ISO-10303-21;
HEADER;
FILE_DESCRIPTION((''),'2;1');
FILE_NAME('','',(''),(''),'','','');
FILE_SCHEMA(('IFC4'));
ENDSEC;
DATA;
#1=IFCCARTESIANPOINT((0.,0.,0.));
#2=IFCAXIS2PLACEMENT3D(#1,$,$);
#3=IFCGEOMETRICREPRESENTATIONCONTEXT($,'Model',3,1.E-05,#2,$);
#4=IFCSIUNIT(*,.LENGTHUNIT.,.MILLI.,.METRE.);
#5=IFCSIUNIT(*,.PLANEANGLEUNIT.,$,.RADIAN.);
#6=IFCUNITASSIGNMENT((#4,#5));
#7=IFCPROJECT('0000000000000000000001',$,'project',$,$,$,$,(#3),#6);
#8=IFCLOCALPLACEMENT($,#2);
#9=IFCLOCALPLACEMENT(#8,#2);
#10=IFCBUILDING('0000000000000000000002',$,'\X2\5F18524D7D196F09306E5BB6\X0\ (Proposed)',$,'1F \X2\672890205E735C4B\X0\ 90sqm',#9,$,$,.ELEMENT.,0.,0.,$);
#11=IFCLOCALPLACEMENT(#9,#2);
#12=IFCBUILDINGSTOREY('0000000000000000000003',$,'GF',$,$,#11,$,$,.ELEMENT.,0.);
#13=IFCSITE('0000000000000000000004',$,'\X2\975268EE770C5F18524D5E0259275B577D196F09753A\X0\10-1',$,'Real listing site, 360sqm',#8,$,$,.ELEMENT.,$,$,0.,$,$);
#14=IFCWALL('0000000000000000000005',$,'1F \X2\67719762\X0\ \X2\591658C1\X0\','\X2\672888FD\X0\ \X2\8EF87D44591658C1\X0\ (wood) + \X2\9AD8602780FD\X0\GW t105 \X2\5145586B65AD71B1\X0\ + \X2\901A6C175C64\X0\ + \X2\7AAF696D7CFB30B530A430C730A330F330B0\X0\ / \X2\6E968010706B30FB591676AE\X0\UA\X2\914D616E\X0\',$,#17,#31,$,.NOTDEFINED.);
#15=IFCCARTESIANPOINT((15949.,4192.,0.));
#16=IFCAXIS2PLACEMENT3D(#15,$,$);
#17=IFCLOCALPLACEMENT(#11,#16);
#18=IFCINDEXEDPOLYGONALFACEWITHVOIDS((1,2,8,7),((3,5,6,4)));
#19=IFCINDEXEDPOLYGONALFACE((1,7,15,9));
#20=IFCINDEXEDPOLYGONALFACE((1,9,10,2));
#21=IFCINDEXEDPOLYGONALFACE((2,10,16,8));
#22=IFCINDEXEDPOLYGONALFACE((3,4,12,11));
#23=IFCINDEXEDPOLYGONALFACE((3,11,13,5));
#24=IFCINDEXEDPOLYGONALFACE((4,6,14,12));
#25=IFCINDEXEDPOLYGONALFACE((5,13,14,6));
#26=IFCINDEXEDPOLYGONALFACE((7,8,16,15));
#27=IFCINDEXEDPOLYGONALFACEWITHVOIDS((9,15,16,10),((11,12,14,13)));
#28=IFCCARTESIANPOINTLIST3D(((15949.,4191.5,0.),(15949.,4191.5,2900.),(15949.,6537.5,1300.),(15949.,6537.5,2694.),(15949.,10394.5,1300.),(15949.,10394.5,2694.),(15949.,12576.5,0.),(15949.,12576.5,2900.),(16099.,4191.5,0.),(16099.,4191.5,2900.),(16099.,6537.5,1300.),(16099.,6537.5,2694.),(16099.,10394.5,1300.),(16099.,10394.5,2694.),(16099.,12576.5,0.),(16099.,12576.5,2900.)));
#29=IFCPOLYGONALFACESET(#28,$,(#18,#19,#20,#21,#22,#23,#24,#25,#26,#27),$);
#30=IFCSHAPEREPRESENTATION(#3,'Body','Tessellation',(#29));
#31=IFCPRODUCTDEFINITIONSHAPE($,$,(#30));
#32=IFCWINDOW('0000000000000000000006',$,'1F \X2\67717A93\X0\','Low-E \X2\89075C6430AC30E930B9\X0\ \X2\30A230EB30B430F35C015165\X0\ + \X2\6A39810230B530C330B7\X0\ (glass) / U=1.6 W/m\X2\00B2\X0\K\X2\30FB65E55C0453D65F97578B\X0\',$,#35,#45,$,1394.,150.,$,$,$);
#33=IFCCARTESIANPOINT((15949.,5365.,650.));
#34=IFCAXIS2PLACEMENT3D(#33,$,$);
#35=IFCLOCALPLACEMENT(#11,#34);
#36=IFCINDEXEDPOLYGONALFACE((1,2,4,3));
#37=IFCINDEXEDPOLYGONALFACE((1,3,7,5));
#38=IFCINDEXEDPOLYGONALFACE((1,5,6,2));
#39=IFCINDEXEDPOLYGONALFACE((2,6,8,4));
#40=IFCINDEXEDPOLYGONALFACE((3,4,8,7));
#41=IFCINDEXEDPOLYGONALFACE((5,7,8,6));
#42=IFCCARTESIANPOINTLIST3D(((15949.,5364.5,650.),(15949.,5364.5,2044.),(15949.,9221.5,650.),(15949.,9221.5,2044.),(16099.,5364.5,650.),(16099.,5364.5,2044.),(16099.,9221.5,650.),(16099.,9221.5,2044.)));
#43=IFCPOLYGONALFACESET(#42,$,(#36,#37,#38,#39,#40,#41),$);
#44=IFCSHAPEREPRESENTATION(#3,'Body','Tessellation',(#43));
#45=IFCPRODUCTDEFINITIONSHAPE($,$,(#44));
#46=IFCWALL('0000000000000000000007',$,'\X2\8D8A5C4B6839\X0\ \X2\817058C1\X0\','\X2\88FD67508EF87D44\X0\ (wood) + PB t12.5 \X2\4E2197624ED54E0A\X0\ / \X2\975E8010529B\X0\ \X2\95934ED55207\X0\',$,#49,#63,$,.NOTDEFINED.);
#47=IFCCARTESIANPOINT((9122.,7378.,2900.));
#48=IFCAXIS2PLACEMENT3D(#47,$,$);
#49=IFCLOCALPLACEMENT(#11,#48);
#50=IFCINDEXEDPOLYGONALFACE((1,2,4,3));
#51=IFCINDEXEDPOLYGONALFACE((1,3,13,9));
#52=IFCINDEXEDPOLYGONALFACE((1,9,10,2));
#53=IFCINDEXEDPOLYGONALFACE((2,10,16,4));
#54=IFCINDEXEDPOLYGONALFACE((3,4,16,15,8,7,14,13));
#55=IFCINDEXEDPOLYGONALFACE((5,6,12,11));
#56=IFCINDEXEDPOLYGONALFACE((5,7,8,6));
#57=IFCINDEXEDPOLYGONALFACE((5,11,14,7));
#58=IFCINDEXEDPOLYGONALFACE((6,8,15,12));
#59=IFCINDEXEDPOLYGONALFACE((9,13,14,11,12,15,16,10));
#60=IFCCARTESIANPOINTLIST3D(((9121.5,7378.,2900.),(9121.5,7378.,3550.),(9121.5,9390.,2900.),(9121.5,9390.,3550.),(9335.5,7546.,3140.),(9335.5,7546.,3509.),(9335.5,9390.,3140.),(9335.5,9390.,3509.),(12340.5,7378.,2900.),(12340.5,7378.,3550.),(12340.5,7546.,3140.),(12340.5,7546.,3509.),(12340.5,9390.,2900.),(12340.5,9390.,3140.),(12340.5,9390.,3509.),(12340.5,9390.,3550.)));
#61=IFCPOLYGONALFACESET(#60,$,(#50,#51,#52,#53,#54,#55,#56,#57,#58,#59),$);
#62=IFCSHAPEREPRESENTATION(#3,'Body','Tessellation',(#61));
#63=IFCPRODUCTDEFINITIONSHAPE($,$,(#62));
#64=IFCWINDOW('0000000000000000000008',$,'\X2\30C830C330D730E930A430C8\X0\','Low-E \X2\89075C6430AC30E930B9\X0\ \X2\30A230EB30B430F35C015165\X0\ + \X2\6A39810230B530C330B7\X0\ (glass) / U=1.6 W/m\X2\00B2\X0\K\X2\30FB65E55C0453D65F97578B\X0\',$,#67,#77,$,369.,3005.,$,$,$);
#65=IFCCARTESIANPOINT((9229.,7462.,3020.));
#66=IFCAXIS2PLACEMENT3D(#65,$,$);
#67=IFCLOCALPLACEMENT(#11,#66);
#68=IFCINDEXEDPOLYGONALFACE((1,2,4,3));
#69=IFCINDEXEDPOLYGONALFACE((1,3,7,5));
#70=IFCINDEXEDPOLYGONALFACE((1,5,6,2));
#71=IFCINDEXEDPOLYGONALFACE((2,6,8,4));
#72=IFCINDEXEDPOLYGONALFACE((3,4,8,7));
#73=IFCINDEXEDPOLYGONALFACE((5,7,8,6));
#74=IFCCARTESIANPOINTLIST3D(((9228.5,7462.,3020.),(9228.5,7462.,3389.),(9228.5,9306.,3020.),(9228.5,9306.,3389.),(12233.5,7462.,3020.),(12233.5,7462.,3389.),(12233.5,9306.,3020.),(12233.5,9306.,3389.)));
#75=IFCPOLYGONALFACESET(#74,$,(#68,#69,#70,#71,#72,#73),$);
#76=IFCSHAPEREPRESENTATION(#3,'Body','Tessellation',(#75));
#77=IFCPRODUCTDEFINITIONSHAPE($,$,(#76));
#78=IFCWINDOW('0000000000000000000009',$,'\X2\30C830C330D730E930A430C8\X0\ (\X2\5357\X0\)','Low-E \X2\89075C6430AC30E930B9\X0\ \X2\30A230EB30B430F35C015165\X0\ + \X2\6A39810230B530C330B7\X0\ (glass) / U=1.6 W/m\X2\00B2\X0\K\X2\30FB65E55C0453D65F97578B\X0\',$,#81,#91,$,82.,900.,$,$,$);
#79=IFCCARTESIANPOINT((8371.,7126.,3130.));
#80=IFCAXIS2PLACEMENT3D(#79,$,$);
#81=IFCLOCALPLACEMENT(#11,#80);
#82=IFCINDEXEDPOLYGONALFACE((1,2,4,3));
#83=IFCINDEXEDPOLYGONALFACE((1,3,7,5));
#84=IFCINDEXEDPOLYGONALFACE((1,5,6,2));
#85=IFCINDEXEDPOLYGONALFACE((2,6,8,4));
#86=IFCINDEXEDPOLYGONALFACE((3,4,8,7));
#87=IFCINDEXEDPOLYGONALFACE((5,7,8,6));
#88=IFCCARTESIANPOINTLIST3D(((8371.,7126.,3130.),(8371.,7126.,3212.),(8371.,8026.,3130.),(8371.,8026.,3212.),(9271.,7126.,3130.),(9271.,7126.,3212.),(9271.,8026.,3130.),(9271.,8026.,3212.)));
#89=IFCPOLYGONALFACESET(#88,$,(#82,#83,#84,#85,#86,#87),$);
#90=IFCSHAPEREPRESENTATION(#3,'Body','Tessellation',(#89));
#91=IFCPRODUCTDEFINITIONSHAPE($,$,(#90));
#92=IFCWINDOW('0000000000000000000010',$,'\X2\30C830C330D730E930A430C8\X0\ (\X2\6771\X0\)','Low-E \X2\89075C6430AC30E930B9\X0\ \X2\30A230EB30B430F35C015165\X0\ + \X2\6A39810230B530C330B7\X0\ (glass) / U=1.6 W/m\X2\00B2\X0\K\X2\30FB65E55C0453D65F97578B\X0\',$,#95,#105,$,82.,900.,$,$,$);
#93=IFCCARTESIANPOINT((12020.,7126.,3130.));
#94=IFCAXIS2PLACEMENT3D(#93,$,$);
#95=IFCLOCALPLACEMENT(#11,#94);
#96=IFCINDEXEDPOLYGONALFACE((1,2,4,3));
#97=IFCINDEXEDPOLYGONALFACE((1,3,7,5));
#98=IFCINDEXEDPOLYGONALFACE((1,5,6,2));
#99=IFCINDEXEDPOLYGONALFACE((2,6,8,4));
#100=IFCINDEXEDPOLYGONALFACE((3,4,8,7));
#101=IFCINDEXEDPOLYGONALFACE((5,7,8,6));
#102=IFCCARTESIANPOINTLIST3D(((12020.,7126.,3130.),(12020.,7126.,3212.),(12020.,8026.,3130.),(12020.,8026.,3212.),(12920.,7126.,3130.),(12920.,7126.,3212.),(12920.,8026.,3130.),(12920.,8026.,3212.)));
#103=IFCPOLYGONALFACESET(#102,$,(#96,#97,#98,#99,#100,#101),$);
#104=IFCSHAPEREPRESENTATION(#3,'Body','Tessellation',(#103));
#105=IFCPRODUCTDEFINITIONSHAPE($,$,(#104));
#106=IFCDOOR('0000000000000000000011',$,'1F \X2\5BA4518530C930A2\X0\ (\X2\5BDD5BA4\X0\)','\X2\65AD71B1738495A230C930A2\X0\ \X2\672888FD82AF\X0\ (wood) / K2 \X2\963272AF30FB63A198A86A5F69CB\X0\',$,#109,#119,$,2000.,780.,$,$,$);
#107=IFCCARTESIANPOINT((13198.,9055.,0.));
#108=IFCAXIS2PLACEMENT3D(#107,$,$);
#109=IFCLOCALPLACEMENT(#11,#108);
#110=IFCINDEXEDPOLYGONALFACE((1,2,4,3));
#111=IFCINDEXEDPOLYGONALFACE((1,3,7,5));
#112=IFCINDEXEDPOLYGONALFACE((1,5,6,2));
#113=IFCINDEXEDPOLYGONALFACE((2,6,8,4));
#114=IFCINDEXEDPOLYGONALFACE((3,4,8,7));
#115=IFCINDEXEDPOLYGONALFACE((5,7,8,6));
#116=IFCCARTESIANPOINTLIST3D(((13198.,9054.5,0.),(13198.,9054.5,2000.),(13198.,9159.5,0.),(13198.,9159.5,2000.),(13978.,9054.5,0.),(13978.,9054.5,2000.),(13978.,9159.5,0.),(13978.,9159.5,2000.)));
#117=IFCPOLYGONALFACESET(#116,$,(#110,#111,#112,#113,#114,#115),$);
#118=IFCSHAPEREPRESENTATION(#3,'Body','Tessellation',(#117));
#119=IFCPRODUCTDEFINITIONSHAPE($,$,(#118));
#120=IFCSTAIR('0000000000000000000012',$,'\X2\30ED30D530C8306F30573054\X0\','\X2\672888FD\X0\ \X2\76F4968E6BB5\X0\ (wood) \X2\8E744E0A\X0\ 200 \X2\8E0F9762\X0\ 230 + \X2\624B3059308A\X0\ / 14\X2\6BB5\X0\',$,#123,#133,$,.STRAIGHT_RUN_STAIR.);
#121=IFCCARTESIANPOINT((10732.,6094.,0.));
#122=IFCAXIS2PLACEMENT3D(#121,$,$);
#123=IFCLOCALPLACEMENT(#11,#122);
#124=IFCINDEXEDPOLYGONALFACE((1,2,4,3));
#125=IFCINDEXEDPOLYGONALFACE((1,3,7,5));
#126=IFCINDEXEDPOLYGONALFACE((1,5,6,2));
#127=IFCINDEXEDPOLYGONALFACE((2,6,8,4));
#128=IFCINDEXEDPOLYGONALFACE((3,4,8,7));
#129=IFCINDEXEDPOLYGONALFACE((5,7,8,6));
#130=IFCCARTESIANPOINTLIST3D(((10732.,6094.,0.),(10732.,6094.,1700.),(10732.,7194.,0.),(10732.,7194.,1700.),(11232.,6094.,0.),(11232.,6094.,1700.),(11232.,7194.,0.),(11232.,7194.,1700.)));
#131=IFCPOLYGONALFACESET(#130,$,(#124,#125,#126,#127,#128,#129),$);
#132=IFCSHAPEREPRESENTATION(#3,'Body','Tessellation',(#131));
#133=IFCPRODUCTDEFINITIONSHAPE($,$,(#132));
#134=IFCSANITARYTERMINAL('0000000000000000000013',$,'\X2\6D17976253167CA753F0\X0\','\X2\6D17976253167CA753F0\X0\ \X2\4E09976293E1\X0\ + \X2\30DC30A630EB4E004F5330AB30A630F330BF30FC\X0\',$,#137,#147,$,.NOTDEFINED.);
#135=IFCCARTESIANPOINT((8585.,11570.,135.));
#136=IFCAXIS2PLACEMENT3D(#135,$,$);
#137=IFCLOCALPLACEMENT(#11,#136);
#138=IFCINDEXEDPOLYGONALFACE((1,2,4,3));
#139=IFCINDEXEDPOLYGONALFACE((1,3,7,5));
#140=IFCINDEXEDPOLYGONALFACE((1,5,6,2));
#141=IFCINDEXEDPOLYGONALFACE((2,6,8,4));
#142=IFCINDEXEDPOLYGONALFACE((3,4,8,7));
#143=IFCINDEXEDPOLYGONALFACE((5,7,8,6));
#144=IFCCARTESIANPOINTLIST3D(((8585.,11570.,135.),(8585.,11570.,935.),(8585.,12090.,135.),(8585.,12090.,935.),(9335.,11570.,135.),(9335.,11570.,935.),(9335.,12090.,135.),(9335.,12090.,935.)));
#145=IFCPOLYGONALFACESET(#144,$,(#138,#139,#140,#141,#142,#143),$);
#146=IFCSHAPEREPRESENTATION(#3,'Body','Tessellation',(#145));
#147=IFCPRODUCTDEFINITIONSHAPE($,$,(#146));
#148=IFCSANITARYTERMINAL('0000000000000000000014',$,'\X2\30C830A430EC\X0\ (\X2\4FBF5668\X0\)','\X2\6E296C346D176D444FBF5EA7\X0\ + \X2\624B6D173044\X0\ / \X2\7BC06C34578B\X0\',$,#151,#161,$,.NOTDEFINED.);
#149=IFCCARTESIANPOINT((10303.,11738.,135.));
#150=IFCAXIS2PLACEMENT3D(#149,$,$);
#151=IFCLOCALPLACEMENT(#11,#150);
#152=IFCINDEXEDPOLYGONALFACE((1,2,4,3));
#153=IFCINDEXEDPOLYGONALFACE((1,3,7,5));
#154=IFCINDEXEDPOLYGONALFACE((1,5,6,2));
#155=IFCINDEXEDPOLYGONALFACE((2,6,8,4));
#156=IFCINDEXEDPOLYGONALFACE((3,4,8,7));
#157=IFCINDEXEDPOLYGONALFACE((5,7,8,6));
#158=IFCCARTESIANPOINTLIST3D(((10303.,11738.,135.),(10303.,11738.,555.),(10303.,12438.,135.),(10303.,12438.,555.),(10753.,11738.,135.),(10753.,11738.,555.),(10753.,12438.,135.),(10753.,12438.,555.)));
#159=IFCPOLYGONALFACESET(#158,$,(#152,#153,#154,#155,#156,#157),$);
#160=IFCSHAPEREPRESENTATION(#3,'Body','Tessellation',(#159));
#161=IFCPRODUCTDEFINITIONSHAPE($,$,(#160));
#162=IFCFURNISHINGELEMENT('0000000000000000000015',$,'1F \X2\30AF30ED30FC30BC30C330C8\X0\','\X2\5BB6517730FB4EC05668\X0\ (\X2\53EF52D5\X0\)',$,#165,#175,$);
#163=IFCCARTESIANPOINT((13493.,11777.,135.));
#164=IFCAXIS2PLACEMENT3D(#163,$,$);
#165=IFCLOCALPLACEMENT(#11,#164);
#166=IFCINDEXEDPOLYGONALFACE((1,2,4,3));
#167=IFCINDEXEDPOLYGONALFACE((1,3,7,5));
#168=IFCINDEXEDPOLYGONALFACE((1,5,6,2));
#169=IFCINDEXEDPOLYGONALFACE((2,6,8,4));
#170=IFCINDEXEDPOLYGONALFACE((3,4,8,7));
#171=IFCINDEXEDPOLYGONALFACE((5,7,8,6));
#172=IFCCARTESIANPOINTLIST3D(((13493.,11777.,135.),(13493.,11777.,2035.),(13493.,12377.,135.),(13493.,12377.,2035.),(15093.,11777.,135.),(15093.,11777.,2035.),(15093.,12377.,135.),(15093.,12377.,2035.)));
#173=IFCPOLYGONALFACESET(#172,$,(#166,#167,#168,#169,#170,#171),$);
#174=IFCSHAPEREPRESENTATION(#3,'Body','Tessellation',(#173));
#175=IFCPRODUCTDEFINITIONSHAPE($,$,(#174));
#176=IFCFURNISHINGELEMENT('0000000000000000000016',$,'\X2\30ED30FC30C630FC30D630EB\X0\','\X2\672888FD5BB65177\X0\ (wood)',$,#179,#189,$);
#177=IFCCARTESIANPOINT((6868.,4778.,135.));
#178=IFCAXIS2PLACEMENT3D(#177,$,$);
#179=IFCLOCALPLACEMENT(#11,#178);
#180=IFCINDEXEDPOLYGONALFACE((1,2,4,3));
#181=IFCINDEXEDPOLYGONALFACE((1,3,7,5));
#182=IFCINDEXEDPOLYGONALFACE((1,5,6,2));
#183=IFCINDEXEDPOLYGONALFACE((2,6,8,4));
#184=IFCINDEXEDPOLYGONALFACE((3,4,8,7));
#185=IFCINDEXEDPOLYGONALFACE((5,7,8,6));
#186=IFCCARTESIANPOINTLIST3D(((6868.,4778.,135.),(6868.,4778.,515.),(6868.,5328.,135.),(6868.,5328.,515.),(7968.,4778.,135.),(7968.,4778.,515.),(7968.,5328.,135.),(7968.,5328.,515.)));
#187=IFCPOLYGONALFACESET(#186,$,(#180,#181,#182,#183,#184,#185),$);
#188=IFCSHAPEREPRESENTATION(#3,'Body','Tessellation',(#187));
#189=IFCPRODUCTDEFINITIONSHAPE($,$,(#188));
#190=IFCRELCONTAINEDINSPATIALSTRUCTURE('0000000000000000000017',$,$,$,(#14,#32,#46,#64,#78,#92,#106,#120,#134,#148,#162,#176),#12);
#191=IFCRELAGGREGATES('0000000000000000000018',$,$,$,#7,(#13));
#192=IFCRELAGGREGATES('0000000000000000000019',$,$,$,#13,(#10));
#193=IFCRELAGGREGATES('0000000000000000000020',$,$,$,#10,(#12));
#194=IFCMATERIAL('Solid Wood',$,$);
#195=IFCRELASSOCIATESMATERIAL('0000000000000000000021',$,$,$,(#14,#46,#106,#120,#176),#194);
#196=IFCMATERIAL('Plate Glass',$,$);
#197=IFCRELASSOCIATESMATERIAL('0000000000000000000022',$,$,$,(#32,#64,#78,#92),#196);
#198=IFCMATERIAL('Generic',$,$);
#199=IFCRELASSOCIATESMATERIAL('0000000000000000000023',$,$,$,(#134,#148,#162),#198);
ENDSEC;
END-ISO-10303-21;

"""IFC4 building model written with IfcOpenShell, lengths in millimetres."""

from ifc_helpers import new_model, si_unit, frame, frame_2d, origin, place, context, project, spatial, rectangle, extrude, material, element, fill, save


model = new_model("IFC4")

# Units and contexts
model_context = context("Model", 3, precision=1e-05, world=origin())
ifc_project = project(units=[si_unit("LENGTHUNIT", "METRE", prefix="MILLI"), si_unit("PLANEANGLEUNIT", "RADIAN")], contexts=[model_context])

# Site, building, storey
site_placement = place(None, origin())
site = spatial("IfcSite", under=ifc_project, at=site_placement, Name="青森県弘前市大字紙漉町10-1", ObjectType="Real listing site, 360sqm", CompositionType="ELEMENT", RefElevation=0.0)
building_placement = place(site_placement, origin())
building = spatial("IfcBuilding", under=site, at=building_placement, Name="弘前紙漉の家 (Proposed)", ObjectType="1F 木造平屋 90sqm", CompositionType="ELEMENT", ElevationOfRefHeight=0.0, ElevationOfTerrain=0.0)
storey_placement = place(building_placement, origin())
storey = spatial("IfcBuildingStorey", under=building, at=storey_placement, Name="GF", CompositionType="ELEMENT", Elevation=0.0)

# Wall, opening, window
ifc_material_1 = material(Name="Solid Wood")
wall_1_placement = place(storey_placement, frame((15949.0, 4192.0, 0.0)))
wall_1 = element("IfcWall", 1, at=wall_1_placement, inside=storey, material=ifc_material_1, Name="1F 東面 外壁", Description="木製 軸組外壁 (wood) + 高性能GW t105 充填断熱 + 通気層 + 窯業系サイディング / 準耐火・外皮UA配慮", PredefinedType="NOTDEFINED", context=model_context, shape_type="SweptSolid", body=[
    extrude(rectangle(XDim=150.0, YDim=8385.0, at=frame_2d((75.0, 4192.0))), frame((15949.0, 4192.0, 0.0)), (0.0, 0.0, 1.0), 2900.0),
])
opening_1_placement = place(storey_placement, frame((15949.0, 5365.0, 650.0)))
opening_1 = element("IfcOpeningElement", 2, at=opening_1_placement, cuts=wall_1, PredefinedType="NOTDEFINED", context=model_context, shape_type="SweptSolid", body=[
    extrude(rectangle(XDim=150.0, YDim=3857.0, at=frame_2d((75.0, 1928.0))), frame((15949.0, 5365.0, 650.0)), (0.0, 0.0, 1.0), 1394.0),
])
ifc_material_2 = material(Name="Plate Glass")
window_1_placement = place(storey_placement, frame((15949.0, 5365.0, 650.0)))
window_1 = element("IfcWindow", 3, at=window_1_placement, inside=storey, material=ifc_material_2, Name="1F 東窓", Description="Low-E 複層ガラス アルゴン封入 + 樹脂サッシ (glass) / U=1.6 W/m²K・日射取得型", OverallHeight=1394.0, OverallWidth=150.0, context=model_context, shape_type="SweptSolid", body=[
    extrude(rectangle(XDim=150.0, YDim=3857.0, at=frame_2d((75.0, 1928.0))), frame((15949.0, 5365.0, 650.0)), (0.0, 0.0, 1.0), 1394.0),
])
fill(opening_1, window_1)

# Wall, openings, windows
wall_2_placement = place(storey_placement, frame((9122.0, 7378.0, 2900.0)))
wall_2 = element("IfcWall", 4, at=wall_2_placement, inside=storey, material=ifc_material_1, Name="越屋根 腰壁", Description="製材軸組 (wood) + PB t12.5 両面仕上 / 非耐力 間仕切", PredefinedType="NOTDEFINED", context=model_context, shape_type="SweptSolid", body=[
    extrude(rectangle(XDim=3219.0, YDim=2012.0, at=frame_2d((1609.0, 1006.0))), frame((9122.0, 7378.0, 2900.0)), (0.0, 0.0, 1.0), 650.0),
])
opening_2_placement = place(storey_placement, frame((9229.0, 7462.0, 3020.0)))
opening_2 = element("IfcOpeningElement", 5, at=opening_2_placement, cuts=wall_2, PredefinedType="NOTDEFINED", context=model_context, shape_type="SweptSolid", body=[
    extrude(rectangle(XDim=3005.0, YDim=1844.0, at=frame_2d((1502.0, 922.0))), frame((9229.0, 7462.0, 3020.0)), (0.0, 0.0, 1.0), 369.0),
])
opening_3_placement = place(storey_placement, frame((8371.0, 7126.0, 3130.0)))
opening_3 = element("IfcOpeningElement", 6, at=opening_3_placement, cuts=wall_2, PredefinedType="NOTDEFINED", context=model_context, shape_type="SweptSolid", body=[
    extrude(rectangle(XDim=900.0, YDim=900.0, at=frame_2d((450.0, 450.0))), frame((8371.0, 7126.0, 3130.0)), (0.0, 0.0, 1.0), 82.0),
])
opening_4_placement = place(storey_placement, frame((12020.0, 7126.0, 3130.0)))
opening_4 = element("IfcOpeningElement", 7, at=opening_4_placement, cuts=wall_2, PredefinedType="NOTDEFINED", context=model_context, shape_type="SweptSolid", body=[
    extrude(rectangle(XDim=900.0, YDim=900.0, at=frame_2d((450.0, 450.0))), frame((12020.0, 7126.0, 3130.0)), (0.0, 0.0, 1.0), 82.0),
])
window_2_placement = place(storey_placement, frame((9229.0, 7462.0, 3020.0)))
window_2 = element("IfcWindow", 8, at=window_2_placement, inside=storey, material=ifc_material_2, Name="トップライト", Description="Low-E 複層ガラス アルゴン封入 + 樹脂サッシ (glass) / U=1.6 W/m²K・日射取得型", OverallHeight=369.0, OverallWidth=3005.0, context=model_context, shape_type="SweptSolid", body=[
    extrude(rectangle(XDim=3005.0, YDim=1844.0, at=frame_2d((1502.0, 922.0))), frame((9229.0, 7462.0, 3020.0)), (0.0, 0.0, 1.0), 369.0),
])
fill(opening_2, window_2)
window_3_placement = place(storey_placement, frame((8371.0, 7126.0, 3130.0)))
window_3 = element("IfcWindow", 9, at=window_3_placement, inside=storey, material=ifc_material_2, Name="トップライト (南)", Description="Low-E 複層ガラス アルゴン封入 + 樹脂サッシ (glass) / U=1.6 W/m²K・日射取得型", OverallHeight=82.0, OverallWidth=900.0, context=model_context, shape_type="SweptSolid", body=[
    extrude(rectangle(XDim=900.0, YDim=900.0, at=frame_2d((450.0, 450.0))), frame((8371.0, 7126.0, 3130.0)), (0.0, 0.0, 1.0), 82.0),
])
fill(opening_3, window_3)
window_4_placement = place(storey_placement, frame((12020.0, 7126.0, 3130.0)))
window_4 = element("IfcWindow", 10, at=window_4_placement, inside=storey, material=ifc_material_2, Name="トップライト (東)", Description="Low-E 複層ガラス アルゴン封入 + 樹脂サッシ (glass) / U=1.6 W/m²K・日射取得型", OverallHeight=82.0, OverallWidth=900.0, context=model_context, shape_type="SweptSolid", body=[
    extrude(rectangle(XDim=900.0, YDim=900.0, at=frame_2d((450.0, 450.0))), frame((12020.0, 7126.0, 3130.0)), (0.0, 0.0, 1.0), 82.0),
])
fill(opening_4, window_4)

# Door
door_placement = place(storey_placement, frame((13198.0, 9055.0, 0.0)))
element("IfcDoor", 11, at=door_placement, inside=storey, material=ifc_material_1, Name="1F 室内ドア (寝室)", Description="断熱玄関ドア 木製芯 (wood) / K2 防犯・採風機構", OverallHeight=2000.0, OverallWidth=780.0, context=model_context, shape_type="SweptSolid", body=[
    extrude(rectangle(XDim=780.0, YDim=105.0, at=frame_2d((390.0, 52.0))), frame((13198.0, 9055.0, 0.0)), (0.0, 0.0, 1.0), 2000.0),
])

# Stair
stair_placement = place(storey_placement, frame((10732.0, 6094.0, 0.0)))
element("IfcStair", 12, at=stair_placement, inside=storey, material=ifc_material_1, Name="ロフトはしご", Description="木製 直階段 (wood) 蹴上 200 踏面 230 + 手すり / 14段", PredefinedType="STRAIGHT_RUN_STAIR", context=model_context, shape_type="SweptSolid", body=[
    extrude(rectangle(XDim=500.0, YDim=1100.0, at=frame_2d((250.0, 550.0))), frame((10732.0, 6094.0, 0.0)), (0.0, 0.0, 1.0), 1700.0),
])

# Sanitary terminals
ifc_material_3 = material(Name="Generic")
sanitary_terminal_1_placement = place(storey_placement, frame((8585.0, 11570.0, 135.0)))
element("IfcSanitaryTerminal", 13, at=sanitary_terminal_1_placement, inside=storey, material=ifc_material_3, Name="洗面化粧台", Description="洗面化粧台 三面鏡 + ボウル一体カウンター", PredefinedType="NOTDEFINED", context=model_context, shape_type="SweptSolid", body=[
    extrude(rectangle(XDim=750.0, YDim=520.0, at=frame_2d((375.0, 260.0))), frame((8585.0, 11570.0, 135.0)), (0.0, 0.0, 1.0), 800.0),
])
sanitary_terminal_2_placement = place(storey_placement, frame((10303.0, 11738.0, 135.0)))
element("IfcSanitaryTerminal", 14, at=sanitary_terminal_2_placement, inside=storey, material=ifc_material_3, Name="トイレ (便器)", Description="温水洗浄便座 + 手洗い / 節水型", PredefinedType="NOTDEFINED", context=model_context, shape_type="SweptSolid", body=[
    extrude(rectangle(XDim=450.0, YDim=700.0, at=frame_2d((225.0, 350.0))), frame((10303.0, 11738.0, 135.0)), (0.0, 0.0, 1.0), 420.0),
])

# Furnishing elements
furnishing_1_placement = place(storey_placement, frame((13493.0, 11777.0, 135.0)))
element("IfcFurnishingElement", 15, at=furnishing_1_placement, inside=storey, material=ifc_material_3, Name="1F クローゼット", Description="家具・什器 (可動)", context=model_context, shape_type="SweptSolid", body=[
    extrude(rectangle(XDim=1600.0, YDim=600.0, at=frame_2d((800.0, 300.0))), frame((13493.0, 11777.0, 135.0)), (0.0, 0.0, 1.0), 1900.0),
])
furnishing_2_placement = place(storey_placement, frame((6868.0, 4778.0, 135.0)))
element("IfcFurnishingElement", 16, at=furnishing_2_placement, inside=storey, material=ifc_material_1, Name="ローテーブル", Description="木製家具 (wood)", context=model_context, shape_type="SweptSolid", body=[
    extrude(rectangle(XDim=1100.0, YDim=550.0, at=frame_2d((550.0, 275.0))), frame((6868.0, 4778.0, 135.0)), (0.0, 0.0, 1.0), 380.0),
])

save(model, "model.ifc")
